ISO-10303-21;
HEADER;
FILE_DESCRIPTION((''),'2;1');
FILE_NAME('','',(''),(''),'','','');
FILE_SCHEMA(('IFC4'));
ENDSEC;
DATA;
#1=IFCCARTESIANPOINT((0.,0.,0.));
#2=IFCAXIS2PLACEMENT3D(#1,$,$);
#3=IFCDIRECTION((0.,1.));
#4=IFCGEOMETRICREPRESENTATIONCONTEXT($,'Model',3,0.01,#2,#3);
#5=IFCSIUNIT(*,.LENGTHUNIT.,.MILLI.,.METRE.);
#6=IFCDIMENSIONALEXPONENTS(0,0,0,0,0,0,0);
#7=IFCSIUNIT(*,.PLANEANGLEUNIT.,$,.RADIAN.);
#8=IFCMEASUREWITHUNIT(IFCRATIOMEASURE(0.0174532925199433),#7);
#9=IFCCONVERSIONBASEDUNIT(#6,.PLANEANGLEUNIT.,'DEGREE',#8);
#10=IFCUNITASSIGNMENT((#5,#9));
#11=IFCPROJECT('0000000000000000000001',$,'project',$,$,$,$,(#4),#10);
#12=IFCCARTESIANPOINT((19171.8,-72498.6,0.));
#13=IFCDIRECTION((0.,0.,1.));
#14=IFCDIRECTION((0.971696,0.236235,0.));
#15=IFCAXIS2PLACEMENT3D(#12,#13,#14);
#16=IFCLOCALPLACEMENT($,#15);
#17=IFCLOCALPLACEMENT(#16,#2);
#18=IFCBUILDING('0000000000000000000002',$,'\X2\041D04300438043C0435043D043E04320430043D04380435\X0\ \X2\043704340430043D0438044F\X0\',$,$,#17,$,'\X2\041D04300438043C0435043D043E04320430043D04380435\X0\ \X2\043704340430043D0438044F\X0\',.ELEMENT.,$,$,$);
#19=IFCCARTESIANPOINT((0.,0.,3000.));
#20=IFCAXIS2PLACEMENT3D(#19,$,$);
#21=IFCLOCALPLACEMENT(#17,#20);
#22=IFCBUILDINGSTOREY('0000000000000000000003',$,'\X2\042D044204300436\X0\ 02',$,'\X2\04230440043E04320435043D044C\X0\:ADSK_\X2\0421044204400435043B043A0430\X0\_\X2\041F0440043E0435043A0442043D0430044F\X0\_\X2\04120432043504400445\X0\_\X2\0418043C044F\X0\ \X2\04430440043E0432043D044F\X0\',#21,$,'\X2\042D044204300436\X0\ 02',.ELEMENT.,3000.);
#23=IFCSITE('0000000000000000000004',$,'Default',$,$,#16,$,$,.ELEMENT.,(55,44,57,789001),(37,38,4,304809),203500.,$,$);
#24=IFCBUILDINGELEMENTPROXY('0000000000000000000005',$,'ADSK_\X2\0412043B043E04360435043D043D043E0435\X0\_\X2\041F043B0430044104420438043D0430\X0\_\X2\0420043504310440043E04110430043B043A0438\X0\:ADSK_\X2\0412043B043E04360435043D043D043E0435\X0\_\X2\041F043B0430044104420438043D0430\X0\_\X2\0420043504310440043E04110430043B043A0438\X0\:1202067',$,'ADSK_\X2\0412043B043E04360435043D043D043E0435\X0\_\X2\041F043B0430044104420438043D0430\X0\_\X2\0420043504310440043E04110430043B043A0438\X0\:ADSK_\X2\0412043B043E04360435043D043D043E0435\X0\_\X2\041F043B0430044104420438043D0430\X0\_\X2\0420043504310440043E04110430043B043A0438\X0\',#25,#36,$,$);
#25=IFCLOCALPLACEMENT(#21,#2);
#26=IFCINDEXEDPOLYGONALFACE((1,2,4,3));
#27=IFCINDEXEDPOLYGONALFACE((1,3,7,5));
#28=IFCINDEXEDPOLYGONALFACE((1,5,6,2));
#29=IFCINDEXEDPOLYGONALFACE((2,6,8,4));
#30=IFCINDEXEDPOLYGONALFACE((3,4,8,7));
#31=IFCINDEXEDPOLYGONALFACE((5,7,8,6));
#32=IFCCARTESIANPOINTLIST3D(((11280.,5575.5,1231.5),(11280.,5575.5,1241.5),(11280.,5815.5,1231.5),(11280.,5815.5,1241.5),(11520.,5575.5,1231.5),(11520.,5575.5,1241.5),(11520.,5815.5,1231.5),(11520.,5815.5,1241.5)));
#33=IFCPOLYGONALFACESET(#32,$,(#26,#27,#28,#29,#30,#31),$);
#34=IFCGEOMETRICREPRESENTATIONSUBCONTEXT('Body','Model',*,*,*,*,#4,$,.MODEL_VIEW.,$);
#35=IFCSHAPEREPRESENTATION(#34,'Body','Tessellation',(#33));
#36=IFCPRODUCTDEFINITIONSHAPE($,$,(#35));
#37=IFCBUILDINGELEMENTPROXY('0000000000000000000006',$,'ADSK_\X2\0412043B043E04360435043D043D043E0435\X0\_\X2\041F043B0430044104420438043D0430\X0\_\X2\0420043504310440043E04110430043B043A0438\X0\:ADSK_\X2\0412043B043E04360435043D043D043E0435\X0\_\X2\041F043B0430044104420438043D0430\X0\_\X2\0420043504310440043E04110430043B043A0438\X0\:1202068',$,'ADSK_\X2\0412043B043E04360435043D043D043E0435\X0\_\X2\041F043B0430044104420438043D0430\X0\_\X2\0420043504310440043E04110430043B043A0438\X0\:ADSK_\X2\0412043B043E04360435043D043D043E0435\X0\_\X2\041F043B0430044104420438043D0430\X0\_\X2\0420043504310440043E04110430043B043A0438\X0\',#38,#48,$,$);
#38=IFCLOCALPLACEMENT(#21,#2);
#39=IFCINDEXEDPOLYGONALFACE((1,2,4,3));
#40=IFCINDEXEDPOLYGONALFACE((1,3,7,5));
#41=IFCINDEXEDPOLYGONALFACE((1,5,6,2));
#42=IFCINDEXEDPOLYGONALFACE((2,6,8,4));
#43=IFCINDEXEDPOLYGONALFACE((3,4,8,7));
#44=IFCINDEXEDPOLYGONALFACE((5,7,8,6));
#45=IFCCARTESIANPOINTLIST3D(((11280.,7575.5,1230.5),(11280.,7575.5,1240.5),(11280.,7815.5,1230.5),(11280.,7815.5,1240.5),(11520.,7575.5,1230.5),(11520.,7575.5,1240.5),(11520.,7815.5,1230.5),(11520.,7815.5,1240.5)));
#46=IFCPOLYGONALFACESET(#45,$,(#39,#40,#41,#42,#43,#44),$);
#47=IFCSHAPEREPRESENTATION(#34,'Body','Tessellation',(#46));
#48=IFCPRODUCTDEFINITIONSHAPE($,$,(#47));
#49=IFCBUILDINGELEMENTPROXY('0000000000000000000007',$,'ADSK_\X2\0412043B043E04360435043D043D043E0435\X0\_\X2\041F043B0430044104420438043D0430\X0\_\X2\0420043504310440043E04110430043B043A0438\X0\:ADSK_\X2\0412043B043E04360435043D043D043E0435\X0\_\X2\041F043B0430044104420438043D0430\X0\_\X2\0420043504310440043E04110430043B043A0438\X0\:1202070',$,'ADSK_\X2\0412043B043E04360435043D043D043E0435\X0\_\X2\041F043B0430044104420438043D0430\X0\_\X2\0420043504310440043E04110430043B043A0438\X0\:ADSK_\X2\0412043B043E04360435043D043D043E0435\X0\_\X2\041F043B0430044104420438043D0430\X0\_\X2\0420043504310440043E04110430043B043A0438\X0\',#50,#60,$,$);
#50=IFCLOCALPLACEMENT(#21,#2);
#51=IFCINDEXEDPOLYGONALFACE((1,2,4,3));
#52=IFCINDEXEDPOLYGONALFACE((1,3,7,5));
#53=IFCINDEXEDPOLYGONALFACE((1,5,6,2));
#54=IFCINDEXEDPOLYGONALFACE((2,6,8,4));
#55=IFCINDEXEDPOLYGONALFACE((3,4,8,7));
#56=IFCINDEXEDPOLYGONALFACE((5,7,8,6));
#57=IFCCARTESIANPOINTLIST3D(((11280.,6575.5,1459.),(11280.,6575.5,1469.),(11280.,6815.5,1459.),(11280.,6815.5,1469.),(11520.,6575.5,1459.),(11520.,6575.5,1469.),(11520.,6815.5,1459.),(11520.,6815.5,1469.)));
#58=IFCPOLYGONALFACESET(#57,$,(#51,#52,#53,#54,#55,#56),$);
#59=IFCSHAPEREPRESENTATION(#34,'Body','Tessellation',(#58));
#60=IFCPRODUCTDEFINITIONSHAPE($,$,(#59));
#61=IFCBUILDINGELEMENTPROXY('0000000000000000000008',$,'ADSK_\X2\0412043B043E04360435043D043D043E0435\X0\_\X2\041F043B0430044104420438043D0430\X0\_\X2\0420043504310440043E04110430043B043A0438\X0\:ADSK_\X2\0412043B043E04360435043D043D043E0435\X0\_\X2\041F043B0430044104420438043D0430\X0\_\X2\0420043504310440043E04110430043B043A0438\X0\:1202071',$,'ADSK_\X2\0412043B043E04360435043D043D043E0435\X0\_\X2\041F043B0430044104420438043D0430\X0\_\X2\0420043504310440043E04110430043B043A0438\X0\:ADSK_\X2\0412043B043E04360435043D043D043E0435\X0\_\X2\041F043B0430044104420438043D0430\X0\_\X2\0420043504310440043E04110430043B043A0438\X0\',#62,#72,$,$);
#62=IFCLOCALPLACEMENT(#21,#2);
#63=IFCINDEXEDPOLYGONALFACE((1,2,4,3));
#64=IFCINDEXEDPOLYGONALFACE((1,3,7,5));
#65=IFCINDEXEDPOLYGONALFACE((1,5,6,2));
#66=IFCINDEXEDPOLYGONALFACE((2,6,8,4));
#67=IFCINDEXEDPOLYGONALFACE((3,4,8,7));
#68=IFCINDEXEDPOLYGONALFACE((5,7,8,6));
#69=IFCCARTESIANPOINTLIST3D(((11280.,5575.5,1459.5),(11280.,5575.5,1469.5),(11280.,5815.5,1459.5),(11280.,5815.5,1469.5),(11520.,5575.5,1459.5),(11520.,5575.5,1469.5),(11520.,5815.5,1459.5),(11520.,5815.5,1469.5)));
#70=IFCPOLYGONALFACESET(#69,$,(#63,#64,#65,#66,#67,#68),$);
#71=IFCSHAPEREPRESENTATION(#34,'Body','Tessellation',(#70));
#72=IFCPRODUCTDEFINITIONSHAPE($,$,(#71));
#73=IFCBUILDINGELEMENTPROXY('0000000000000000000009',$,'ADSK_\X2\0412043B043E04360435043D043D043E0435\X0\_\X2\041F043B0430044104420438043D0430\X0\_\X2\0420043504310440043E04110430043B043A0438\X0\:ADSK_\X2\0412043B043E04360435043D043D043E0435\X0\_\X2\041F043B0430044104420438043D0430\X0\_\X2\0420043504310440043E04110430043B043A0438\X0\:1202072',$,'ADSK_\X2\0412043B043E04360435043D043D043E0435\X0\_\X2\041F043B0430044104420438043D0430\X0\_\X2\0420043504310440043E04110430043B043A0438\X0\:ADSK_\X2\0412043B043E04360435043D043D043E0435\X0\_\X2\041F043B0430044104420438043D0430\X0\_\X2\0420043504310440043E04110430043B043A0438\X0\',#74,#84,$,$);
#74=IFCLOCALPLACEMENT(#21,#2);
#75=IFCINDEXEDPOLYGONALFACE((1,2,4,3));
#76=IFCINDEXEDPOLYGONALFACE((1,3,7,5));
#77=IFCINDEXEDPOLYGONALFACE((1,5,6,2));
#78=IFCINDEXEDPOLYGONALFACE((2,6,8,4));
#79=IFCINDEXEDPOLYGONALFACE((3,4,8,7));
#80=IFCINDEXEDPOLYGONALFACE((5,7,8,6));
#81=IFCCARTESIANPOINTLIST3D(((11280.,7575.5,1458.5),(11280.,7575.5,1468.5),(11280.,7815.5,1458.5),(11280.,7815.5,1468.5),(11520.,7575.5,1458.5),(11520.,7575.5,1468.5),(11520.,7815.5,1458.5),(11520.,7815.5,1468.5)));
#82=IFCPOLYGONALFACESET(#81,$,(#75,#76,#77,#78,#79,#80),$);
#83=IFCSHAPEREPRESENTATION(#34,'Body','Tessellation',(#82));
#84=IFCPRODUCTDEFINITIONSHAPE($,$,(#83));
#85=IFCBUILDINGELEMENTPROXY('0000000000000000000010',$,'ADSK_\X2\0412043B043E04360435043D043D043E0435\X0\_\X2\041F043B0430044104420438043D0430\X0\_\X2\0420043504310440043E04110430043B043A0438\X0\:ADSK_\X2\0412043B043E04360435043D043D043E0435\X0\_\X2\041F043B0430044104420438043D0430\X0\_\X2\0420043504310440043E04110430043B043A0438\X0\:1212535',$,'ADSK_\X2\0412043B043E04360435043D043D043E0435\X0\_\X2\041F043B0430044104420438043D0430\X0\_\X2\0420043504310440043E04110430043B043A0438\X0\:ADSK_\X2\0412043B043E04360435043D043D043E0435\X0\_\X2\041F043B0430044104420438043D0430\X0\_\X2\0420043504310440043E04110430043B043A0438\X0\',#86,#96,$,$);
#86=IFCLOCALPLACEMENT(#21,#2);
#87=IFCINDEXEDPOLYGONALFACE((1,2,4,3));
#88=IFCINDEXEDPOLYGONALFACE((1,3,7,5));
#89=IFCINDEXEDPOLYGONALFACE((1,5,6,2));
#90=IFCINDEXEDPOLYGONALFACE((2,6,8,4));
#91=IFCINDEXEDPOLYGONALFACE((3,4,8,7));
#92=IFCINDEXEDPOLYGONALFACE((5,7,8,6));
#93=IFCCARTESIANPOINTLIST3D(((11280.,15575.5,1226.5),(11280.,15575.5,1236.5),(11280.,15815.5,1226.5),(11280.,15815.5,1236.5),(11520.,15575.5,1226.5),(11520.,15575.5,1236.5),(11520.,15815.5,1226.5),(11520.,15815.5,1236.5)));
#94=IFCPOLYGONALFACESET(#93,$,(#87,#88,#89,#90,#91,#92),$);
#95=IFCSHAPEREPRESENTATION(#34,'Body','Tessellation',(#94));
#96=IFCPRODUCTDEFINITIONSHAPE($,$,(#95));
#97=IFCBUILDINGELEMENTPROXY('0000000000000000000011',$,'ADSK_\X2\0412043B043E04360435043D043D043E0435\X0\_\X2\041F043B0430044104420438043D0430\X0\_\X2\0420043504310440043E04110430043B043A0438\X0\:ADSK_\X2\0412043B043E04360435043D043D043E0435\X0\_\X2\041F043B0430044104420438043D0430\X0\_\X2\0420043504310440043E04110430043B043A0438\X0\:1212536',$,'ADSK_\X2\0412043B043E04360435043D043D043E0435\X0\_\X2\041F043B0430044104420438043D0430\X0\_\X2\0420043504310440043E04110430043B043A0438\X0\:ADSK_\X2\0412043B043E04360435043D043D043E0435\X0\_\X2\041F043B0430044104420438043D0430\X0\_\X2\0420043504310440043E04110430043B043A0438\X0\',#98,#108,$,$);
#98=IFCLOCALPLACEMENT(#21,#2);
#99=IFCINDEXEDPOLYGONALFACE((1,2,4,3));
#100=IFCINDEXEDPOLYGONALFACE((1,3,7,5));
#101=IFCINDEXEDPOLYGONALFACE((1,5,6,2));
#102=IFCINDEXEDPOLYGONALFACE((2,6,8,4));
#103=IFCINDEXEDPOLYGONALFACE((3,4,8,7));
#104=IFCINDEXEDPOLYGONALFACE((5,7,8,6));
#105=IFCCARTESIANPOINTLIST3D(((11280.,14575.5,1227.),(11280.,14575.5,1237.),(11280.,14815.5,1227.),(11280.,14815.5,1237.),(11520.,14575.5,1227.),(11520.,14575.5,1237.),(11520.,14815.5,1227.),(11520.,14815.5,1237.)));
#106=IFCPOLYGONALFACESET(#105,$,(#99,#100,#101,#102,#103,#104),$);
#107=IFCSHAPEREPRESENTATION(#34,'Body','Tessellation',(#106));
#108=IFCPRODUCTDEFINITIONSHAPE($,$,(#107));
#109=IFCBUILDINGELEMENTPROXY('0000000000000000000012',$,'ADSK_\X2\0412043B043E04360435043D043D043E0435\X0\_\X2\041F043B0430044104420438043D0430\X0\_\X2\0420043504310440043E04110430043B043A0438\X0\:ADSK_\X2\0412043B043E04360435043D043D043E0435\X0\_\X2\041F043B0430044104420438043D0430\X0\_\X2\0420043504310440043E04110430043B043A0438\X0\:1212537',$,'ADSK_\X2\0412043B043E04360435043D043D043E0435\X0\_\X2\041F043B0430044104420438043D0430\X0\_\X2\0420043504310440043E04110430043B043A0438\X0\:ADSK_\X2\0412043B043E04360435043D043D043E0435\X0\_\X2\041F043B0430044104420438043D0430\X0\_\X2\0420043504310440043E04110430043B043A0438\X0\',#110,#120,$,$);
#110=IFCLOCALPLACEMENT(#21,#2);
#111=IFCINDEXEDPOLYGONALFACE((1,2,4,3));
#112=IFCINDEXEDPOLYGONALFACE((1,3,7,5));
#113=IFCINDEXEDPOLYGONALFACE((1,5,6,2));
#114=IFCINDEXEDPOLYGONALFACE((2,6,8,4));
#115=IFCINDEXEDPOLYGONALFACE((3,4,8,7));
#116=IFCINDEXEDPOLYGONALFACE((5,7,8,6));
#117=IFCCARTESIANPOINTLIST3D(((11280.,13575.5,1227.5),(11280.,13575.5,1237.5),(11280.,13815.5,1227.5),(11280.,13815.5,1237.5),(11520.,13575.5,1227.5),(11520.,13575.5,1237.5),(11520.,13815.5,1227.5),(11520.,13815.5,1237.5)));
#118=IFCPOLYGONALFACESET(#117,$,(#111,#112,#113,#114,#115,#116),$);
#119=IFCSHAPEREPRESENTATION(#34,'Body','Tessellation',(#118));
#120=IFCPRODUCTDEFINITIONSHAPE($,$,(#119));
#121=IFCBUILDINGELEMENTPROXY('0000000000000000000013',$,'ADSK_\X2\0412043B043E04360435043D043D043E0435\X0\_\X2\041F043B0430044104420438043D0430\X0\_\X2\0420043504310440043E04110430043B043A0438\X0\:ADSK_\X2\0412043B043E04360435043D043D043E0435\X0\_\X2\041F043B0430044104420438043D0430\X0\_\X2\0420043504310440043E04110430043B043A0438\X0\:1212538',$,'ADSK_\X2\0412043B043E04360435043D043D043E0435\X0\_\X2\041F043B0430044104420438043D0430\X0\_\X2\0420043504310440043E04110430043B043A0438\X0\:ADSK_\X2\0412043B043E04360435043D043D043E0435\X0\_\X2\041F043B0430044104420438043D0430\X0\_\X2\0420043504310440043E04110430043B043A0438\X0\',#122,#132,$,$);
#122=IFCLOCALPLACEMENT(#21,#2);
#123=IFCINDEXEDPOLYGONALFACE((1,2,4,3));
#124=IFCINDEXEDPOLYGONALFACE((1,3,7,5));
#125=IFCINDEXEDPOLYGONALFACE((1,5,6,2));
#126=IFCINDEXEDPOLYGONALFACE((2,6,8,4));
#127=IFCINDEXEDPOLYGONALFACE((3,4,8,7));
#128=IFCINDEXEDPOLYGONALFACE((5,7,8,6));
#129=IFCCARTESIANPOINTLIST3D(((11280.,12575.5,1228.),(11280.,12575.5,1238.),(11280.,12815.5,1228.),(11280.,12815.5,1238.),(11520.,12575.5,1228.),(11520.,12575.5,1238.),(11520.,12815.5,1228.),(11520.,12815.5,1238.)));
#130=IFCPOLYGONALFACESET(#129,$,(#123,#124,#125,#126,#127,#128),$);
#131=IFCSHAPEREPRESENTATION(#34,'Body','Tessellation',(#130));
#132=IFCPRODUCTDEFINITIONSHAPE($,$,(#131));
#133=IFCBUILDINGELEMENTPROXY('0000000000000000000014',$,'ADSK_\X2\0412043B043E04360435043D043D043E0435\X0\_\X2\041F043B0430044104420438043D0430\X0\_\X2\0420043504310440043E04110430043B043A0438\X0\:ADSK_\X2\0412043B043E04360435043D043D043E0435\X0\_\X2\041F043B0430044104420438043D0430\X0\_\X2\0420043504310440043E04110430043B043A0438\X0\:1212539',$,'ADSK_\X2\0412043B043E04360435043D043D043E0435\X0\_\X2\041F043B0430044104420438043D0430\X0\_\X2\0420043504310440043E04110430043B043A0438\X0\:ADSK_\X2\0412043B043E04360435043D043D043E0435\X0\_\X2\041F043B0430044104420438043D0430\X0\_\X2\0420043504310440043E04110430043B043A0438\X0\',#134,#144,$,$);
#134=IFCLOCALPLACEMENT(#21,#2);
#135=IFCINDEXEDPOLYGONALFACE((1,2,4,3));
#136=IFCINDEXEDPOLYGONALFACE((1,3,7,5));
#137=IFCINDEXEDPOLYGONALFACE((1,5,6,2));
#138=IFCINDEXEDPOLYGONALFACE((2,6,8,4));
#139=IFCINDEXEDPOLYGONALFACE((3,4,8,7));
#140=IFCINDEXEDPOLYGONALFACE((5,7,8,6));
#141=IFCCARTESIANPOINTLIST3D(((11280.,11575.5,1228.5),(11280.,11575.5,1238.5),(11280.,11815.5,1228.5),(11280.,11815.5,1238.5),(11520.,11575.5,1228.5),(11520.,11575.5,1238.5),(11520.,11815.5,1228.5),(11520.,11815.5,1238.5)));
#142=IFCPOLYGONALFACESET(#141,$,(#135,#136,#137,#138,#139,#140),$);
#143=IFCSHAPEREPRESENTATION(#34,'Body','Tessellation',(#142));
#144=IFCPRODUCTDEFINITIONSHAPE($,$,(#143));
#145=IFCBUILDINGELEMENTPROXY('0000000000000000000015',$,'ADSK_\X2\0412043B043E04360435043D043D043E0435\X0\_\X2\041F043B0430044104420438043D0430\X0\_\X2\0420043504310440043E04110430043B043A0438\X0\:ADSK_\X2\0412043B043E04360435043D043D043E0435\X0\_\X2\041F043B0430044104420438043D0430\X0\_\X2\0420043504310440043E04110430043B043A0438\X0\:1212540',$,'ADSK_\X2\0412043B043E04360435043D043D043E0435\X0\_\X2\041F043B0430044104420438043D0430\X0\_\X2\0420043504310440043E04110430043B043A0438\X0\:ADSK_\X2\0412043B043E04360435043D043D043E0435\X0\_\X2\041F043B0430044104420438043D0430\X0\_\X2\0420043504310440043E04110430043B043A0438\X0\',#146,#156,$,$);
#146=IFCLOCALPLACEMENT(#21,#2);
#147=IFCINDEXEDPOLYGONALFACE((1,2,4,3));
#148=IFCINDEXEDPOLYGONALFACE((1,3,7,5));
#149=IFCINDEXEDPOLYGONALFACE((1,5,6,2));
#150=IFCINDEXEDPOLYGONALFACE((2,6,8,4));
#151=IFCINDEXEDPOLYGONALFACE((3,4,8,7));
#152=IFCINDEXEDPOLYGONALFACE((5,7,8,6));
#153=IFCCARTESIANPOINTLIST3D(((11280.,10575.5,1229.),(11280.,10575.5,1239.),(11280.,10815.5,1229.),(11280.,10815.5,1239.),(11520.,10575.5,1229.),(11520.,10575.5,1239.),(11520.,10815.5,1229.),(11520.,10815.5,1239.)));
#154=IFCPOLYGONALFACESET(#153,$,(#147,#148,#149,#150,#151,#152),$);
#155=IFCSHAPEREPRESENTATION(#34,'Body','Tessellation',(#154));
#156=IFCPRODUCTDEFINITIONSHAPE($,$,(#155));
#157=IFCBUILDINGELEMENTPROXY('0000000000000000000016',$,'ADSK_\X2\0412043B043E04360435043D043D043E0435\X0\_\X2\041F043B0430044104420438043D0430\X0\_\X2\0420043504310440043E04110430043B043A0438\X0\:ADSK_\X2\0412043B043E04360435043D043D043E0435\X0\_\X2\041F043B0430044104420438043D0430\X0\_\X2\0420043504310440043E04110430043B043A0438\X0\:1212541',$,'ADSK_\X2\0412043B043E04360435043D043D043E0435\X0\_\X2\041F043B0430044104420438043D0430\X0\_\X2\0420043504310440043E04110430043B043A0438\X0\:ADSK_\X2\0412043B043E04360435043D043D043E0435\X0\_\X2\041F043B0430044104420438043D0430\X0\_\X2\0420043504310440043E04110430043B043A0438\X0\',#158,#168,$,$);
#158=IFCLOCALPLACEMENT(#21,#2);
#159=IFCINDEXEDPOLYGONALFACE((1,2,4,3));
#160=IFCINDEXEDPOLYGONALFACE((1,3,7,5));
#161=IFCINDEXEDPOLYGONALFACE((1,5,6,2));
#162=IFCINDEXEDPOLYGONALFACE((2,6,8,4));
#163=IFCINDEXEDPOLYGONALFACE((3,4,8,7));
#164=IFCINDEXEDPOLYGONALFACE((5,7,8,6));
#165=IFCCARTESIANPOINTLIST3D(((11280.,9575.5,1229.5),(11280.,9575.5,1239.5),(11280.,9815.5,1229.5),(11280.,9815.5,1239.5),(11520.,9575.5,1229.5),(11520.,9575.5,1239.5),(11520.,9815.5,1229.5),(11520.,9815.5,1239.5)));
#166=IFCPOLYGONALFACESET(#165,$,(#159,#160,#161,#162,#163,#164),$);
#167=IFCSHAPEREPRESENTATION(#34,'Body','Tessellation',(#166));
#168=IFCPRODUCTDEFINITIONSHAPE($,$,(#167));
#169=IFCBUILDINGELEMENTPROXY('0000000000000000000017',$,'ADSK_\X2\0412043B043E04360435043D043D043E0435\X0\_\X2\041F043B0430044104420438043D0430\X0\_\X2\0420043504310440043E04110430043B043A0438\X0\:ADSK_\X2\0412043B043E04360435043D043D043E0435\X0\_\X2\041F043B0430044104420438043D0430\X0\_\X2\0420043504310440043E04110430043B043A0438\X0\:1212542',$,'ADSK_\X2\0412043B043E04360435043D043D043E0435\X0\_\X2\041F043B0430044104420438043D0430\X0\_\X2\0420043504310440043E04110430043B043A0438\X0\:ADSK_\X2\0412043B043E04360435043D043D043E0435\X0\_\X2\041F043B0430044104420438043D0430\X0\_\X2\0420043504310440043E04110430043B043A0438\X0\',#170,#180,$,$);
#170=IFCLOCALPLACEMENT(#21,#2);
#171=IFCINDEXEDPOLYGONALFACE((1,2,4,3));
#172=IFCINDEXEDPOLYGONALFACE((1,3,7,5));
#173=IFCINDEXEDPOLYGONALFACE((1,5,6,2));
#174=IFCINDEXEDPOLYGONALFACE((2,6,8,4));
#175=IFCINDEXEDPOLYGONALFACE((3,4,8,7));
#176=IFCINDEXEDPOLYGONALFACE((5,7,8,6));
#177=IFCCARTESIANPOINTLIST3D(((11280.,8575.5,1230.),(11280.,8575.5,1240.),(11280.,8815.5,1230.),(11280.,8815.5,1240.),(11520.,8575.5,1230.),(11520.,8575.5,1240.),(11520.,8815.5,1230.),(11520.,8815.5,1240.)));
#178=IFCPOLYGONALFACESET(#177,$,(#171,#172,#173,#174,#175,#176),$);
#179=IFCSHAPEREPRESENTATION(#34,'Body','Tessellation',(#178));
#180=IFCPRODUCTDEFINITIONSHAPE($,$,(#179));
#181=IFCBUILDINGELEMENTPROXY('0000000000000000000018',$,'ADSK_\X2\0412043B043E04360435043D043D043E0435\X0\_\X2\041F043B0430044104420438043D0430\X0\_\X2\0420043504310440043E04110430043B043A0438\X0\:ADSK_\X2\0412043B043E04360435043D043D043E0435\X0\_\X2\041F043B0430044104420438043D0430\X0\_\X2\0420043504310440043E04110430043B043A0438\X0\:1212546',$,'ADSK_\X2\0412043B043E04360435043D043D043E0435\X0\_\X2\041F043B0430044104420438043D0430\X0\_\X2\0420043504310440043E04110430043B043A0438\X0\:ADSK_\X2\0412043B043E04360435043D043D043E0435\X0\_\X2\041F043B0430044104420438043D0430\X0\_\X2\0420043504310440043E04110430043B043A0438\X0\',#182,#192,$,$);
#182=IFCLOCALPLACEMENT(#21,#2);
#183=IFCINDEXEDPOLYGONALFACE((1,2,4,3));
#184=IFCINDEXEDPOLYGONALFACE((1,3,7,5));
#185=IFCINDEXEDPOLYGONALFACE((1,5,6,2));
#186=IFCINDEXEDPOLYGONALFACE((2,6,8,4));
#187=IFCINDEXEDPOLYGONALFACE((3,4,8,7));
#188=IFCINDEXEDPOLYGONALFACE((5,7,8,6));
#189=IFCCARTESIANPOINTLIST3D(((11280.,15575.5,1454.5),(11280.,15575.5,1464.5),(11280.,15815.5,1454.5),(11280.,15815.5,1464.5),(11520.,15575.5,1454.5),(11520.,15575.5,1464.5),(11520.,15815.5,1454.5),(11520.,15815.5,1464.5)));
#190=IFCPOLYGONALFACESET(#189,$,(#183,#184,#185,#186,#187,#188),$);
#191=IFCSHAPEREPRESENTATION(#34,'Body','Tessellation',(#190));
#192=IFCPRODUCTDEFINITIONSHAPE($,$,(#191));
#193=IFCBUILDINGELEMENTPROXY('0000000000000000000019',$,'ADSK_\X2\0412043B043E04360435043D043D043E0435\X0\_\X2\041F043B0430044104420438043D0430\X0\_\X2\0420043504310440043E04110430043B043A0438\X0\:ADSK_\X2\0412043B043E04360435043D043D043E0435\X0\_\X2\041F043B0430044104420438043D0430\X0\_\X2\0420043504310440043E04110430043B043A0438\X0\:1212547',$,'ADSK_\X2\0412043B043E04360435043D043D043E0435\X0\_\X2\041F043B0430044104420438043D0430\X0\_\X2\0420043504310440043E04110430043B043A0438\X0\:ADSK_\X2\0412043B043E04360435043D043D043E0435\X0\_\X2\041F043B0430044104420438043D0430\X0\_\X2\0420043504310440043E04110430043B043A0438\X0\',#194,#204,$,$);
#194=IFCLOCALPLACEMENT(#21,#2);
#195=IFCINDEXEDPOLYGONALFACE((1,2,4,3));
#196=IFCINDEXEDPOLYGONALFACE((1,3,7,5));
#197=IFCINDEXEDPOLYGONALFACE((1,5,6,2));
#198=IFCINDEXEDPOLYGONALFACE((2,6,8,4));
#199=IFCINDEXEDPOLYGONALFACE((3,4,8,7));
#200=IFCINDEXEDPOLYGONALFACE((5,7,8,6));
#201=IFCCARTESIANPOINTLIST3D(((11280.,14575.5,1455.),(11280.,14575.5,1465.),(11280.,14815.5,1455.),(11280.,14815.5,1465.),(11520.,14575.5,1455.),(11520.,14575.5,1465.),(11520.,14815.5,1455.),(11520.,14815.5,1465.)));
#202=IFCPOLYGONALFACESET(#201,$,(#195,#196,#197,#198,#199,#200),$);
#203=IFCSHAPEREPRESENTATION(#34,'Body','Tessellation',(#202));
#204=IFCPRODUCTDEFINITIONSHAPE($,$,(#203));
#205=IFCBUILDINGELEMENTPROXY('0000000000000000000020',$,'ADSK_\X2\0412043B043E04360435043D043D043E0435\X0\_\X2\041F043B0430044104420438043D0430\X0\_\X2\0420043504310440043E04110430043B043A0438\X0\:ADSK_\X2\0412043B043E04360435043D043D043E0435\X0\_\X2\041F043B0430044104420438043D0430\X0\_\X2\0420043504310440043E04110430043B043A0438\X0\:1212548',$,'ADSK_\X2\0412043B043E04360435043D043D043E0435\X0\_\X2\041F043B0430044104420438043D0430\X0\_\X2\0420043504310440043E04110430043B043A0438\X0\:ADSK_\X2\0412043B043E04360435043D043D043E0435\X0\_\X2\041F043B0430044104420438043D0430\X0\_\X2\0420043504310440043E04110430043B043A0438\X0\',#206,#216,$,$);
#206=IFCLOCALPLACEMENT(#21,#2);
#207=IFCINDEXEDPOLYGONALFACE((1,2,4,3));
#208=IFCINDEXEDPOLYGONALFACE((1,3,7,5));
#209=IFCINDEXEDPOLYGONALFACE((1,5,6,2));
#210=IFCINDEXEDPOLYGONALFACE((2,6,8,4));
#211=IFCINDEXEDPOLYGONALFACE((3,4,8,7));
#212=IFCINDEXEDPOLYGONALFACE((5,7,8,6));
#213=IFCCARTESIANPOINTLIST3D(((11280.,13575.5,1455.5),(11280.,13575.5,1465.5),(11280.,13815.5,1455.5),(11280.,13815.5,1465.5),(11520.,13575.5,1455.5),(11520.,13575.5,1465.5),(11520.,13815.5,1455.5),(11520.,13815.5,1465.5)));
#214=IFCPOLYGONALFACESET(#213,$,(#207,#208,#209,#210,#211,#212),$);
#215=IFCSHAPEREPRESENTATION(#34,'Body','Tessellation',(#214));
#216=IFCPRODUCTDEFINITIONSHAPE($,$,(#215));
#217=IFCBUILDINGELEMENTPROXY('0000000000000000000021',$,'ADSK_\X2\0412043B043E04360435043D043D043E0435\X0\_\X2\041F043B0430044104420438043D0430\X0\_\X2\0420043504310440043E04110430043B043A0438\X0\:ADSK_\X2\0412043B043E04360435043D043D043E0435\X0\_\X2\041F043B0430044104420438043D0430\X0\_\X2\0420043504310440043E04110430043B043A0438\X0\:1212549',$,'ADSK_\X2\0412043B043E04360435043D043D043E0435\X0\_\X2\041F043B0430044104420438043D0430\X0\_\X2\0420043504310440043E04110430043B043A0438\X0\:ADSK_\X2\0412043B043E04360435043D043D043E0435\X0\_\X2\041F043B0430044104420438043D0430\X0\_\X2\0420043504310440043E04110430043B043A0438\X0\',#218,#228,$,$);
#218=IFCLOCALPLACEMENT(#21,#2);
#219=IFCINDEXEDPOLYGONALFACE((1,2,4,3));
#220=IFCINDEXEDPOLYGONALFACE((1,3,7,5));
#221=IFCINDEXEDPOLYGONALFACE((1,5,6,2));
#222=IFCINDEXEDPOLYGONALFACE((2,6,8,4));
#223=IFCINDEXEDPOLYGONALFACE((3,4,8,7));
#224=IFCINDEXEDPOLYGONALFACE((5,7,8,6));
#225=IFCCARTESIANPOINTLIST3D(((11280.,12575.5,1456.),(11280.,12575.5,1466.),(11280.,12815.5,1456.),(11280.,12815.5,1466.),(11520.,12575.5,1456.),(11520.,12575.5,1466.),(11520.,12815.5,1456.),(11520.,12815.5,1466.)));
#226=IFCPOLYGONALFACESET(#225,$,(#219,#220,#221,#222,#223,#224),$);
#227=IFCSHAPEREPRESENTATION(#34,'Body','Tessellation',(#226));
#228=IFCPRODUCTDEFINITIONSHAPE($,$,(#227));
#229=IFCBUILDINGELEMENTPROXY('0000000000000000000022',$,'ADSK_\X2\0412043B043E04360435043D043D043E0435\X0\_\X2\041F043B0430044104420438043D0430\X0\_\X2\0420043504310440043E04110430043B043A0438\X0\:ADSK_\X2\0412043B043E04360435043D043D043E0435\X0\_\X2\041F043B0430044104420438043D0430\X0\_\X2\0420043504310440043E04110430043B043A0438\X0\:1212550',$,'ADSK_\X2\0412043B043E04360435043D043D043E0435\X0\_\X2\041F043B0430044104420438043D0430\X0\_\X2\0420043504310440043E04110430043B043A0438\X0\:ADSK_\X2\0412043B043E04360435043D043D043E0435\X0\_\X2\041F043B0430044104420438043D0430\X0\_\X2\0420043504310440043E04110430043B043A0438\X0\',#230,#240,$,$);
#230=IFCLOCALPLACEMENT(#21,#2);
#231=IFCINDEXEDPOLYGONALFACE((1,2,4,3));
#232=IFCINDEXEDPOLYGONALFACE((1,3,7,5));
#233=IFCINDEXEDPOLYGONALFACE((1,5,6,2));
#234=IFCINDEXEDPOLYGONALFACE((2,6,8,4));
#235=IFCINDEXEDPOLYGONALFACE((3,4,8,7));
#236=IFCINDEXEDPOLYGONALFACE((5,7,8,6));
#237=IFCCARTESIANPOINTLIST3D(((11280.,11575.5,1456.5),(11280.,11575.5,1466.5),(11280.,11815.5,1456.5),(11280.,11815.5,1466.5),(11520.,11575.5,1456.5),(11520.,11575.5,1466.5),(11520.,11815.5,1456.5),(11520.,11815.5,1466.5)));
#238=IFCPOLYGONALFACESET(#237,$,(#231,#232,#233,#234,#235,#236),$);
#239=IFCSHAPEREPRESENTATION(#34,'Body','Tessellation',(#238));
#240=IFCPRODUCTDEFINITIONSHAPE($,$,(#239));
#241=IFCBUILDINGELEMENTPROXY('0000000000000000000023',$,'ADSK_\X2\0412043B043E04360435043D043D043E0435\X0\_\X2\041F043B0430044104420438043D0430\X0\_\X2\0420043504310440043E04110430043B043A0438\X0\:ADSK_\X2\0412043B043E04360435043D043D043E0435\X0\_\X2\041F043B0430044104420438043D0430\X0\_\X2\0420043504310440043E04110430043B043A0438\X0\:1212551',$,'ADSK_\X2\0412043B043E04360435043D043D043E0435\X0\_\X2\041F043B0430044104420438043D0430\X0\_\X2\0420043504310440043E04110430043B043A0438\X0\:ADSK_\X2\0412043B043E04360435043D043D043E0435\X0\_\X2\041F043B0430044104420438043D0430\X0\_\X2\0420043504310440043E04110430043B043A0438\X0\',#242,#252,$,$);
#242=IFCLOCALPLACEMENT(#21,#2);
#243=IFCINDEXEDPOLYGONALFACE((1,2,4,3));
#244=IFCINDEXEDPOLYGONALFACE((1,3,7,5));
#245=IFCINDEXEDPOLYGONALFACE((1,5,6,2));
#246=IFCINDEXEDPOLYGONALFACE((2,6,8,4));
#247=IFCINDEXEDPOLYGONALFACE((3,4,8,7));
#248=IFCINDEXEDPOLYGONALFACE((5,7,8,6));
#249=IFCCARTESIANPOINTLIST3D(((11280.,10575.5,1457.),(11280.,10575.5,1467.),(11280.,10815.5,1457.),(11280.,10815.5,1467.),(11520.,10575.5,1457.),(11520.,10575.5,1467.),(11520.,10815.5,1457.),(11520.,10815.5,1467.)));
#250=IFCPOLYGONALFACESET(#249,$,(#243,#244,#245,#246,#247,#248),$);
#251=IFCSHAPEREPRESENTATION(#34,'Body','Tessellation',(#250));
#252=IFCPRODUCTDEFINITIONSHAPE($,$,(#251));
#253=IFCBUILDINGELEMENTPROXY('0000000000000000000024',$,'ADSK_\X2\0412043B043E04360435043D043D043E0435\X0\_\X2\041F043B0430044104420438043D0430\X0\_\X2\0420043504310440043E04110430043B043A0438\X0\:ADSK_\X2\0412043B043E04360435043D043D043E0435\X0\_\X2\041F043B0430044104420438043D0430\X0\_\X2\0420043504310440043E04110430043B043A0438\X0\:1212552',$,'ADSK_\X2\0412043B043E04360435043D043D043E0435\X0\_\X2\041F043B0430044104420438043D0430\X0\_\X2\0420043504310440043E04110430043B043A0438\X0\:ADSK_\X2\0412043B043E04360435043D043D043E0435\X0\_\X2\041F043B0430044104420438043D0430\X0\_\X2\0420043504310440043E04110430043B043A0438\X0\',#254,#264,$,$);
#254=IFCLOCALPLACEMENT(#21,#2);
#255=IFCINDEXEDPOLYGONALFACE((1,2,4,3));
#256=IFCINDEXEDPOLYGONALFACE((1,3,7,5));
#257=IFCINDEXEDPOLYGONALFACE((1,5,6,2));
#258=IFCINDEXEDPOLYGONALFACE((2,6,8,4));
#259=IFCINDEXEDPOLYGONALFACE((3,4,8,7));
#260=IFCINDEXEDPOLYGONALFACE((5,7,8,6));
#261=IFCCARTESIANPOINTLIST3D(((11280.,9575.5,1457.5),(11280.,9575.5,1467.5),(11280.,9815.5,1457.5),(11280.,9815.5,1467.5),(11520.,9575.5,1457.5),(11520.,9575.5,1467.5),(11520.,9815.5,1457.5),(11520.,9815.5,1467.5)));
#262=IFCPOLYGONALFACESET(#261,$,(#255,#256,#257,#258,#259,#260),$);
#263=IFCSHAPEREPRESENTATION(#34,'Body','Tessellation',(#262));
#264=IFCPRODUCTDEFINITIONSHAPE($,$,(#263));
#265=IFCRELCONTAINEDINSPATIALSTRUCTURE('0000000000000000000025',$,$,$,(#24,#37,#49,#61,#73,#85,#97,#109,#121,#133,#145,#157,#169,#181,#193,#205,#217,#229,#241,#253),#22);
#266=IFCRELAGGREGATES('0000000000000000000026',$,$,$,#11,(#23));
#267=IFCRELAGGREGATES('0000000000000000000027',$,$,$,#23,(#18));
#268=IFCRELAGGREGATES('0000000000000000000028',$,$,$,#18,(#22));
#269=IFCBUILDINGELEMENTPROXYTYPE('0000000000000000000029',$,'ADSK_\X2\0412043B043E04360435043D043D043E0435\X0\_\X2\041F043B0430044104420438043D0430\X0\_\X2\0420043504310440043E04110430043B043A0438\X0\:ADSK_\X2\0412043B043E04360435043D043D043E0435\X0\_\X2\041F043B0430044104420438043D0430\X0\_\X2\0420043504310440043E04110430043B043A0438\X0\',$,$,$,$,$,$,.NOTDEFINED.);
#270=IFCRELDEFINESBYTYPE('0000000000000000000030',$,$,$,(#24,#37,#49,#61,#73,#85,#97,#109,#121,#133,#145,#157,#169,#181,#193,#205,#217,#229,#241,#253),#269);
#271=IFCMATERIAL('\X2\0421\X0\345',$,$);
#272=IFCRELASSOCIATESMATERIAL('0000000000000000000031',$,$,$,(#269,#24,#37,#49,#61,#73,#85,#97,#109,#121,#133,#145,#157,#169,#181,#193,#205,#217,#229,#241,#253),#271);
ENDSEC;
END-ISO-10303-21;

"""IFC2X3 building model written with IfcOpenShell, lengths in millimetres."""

from ifc_helpers import new_model, entity, si_unit, converted_unit, direction, frame, origin, origin_2d_with_axis, place, context, subcontext, project, spatial, rectangle, extrude, source, transform, mapped, material, type_object, type_shapes, element, save


model = new_model("IFC2X3")

# Units and contexts
model_context = context("Model", 3, precision=0.01, world=origin(), true_north=direction((0.0, 1.0)))
body_context = subcontext(model_context, "Body", "Model", "MODEL_VIEW")
ifc_project = project(units=[si_unit("LENGTHUNIT", "METRE", prefix="MILLI"), converted_unit("PLANEANGLEUNIT", "DEGREE", entity("IfcRatioMeasure", 0.0174532925199433), si_unit("PLANEANGLEUNIT", "RADIAN"), dimensions=[0, 0, 0, 0, 0, 0, 0])], contexts=[model_context])

# Site, building, storey
site_placement = place(None, frame((19171.8, -72498.6, 0.0), z_axis=(0.0, 0.0, 1.0), x_axis=(0.971696, 0.236235, 0.0)))
site = spatial("IfcSite", under=ifc_project, at=site_placement, Name="Default", CompositionType="ELEMENT", RefLatitude=(55, 44, 57, 789001), RefLongitude=(37, 38, 4, 304809), RefElevation=203500.0)
building_placement = place(site_placement, origin())
building = spatial("IfcBuilding", under=site, at=building_placement, Name="Наименование здания", LongName="Наименование здания", CompositionType="ELEMENT")
storey_placement = place(building_placement, frame((0.0, 0.0, 3000.0)))
storey = spatial("IfcBuildingStorey", under=building, at=storey_placement, Name="Этаж 02", ObjectType="Уровень:ADSK_Стрелка_Проектная_Вверх_Имя уровня", LongName="Этаж 02", CompositionType="ELEMENT", Elevation=3000.0)

# Shared definitions
ifc_material_1 = material(Name="С345")

# Building element proxies
building_element_proxy_type = type_object("IfcBuildingElementProxyType", Name="ADSK_Вложенное_Пластина_РеброБалки:ADSK_Вложенное_Пластина_РеброБалки", PredefinedType="NOTDEFINED", material=ifc_material_1)
shared_shape_1 = source(origin(), body_context, "Body", "SweptSolid", [
    extrude(rectangle(XDim=10.0, YDim=240.0, at=origin_2d_with_axis()), frame((0.0, 0.0, -120.0), z_axis=(0.0, 0.0, 1.0), x_axis=(0.0, 1.0, 0.0)), (0.0, 0.0, 1.0), 240.0),
])
type_shapes(building_element_proxy_type, [shared_shape_1])
for number, where, z_axis, x_axis, name in (
    (1, (11400.0, 5695.5, 1236.5), (0.0, 1.0, 0.0), (1.0, 0.0, 0.0), "ADSK_Вложенное_Пластина_РеброБалки:ADSK_Вложенное_Пластина_РеброБалки:1202067"),
    (2, (11400.0, 7695.5, 1235.5), (0.0, 1.0, 0.0), (1.0, 0.0, 0.0), "ADSK_Вложенное_Пластина_РеброБалки:ADSK_Вложенное_Пластина_РеброБалки:1202068"),
    (3, (11400.0, 6695.5, 1464.0), (0.0, 1.0, 0.0), (1.0, 0.0, 0.0), "ADSK_Вложенное_Пластина_РеброБалки:ADSK_Вложенное_Пластина_РеброБалки:1202070"),
    (4, (11400.0, 5695.5, 1464.5), (0.0, 1.0, 0.0), (1.0, 0.0, 0.0), "ADSK_Вложенное_Пластина_РеброБалки:ADSK_Вложенное_Пластина_РеброБалки:1202071"),
    (5, (11400.0, 7695.5, 1463.5), (0.0, 1.0, 0.0), (1.0, 0.0, 0.0), "ADSK_Вложенное_Пластина_РеброБалки:ADSK_Вложенное_Пластина_РеброБалки:1202072"),
    (6, (11400.0, 15695.5, 1231.5), (0.0, 1.0, 0.0), (1.0, 0.0, 0.0), "ADSK_Вложенное_Пластина_РеброБалки:ADSK_Вложенное_Пластина_РеброБалки:1212535"),
    (7, (11400.0, 14695.5, 1232.0), (0.0, 1.0, 0.0), (1.0, 0.0, 0.0), "ADSK_Вложенное_Пластина_РеброБалки:ADSK_Вложенное_Пластина_РеброБалки:1212536"),
    (8, (11400.0, 13695.5, 1232.5), (0.0, 1.0, 0.0), (1.0, 0.0, 0.0), "ADSK_Вложенное_Пластина_РеброБалки:ADSK_Вложенное_Пластина_РеброБалки:1212537"),
    (9, (11400.0, 12695.5, 1233.0), (0.0, 1.0, 0.0), (1.0, 0.0, 0.0), "ADSK_Вложенное_Пластина_РеброБалки:ADSK_Вложенное_Пластина_РеброБалки:1212538"),
    (10, (11400.0, 11695.5, 1233.5), (0.0, 1.0, 0.0), (1.0, 0.0, 0.0), "ADSK_Вложенное_Пластина_РеброБалки:ADSK_Вложенное_Пластина_РеброБалки:1212539"),
    (11, (11400.0, 10695.5, 1234.0), (0.0, 1.0, 0.0), (1.0, 0.0, 0.0), "ADSK_Вложенное_Пластина_РеброБалки:ADSK_Вложенное_Пластина_РеброБалки:1212540"),
    (12, (11400.0, 9695.5, 1234.5), (0.0, 1.0, 0.0), (1.0, 0.0, 0.0), "ADSK_Вложенное_Пластина_РеброБалки:ADSK_Вложенное_Пластина_РеброБалки:1212541"),
    (13, (11400.0, 8695.5, 1235.0), (0.0, 1.0, 0.0), (1.0, 0.0, 0.0), "ADSK_Вложенное_Пластина_РеброБалки:ADSK_Вложенное_Пластина_РеброБалки:1212542"),
    (14, (11400.0, 15695.5, 1459.5), (0.0, 1.0, 0.0), (1.0, 0.0, 0.0), "ADSK_Вложенное_Пластина_РеброБалки:ADSK_Вложенное_Пластина_РеброБалки:1212546"),
    (15, (11400.0, 14695.5, 1460.0), (0.0, 1.0, 0.0), (1.0, 0.0, 0.0), "ADSK_Вложенное_Пластина_РеброБалки:ADSK_Вложенное_Пластина_РеброБалки:1212547"),
    (16, (11400.0, 13695.5, 1460.5), (0.0, 1.0, 0.0), (1.0, 0.0, 0.0), "ADSK_Вложенное_Пластина_РеброБалки:ADSK_Вложенное_Пластина_РеброБалки:1212548"),
    (17, (11400.0, 12695.5, 1461.0), (0.0, 1.0, 0.0), (1.0, 0.0, 0.0), "ADSK_Вложенное_Пластина_РеброБалки:ADSK_Вложенное_Пластина_РеброБалки:1212549"),
    (18, (11400.0, 11695.5, 1461.5), (0.0, 1.0, 0.0), (1.0, 0.0, 0.0), "ADSK_Вложенное_Пластина_РеброБалки:ADSK_Вложенное_Пластина_РеброБалки:1212550"),
    (19, (11400.0, 10695.5, 1462.0), (0.0, 1.0, 0.0), (1.0, 0.0, 0.0), "ADSK_Вложенное_Пластина_РеброБалки:ADSK_Вложенное_Пластина_РеброБалки:1212551"),
    (20, (11400.0, 9695.5, 1462.5), (0.0, 1.0, 0.0), (1.0, 0.0, 0.0), "ADSK_Вложенное_Пластина_РеброБалки:ADSK_Вложенное_Пластина_РеброБалки:1212552"),
):
    element("IfcBuildingElementProxy", number, at=place(storey_placement, frame(where, z_axis=z_axis, x_axis=x_axis)), inside=storey, type_object=building_element_proxy_type, material=ifc_material_1, Name=name, ObjectType="ADSK_Вложенное_Пластина_РеброБалки:ADSK_Вложенное_Пластина_РеброБалки", context=body_context, shape_type="MappedRepresentation", body=[
        mapped(shared_shape_1, transform((0.0, 0.0, 0.0), scale=1.0)),
    ])

save(model, "model.ifc")
